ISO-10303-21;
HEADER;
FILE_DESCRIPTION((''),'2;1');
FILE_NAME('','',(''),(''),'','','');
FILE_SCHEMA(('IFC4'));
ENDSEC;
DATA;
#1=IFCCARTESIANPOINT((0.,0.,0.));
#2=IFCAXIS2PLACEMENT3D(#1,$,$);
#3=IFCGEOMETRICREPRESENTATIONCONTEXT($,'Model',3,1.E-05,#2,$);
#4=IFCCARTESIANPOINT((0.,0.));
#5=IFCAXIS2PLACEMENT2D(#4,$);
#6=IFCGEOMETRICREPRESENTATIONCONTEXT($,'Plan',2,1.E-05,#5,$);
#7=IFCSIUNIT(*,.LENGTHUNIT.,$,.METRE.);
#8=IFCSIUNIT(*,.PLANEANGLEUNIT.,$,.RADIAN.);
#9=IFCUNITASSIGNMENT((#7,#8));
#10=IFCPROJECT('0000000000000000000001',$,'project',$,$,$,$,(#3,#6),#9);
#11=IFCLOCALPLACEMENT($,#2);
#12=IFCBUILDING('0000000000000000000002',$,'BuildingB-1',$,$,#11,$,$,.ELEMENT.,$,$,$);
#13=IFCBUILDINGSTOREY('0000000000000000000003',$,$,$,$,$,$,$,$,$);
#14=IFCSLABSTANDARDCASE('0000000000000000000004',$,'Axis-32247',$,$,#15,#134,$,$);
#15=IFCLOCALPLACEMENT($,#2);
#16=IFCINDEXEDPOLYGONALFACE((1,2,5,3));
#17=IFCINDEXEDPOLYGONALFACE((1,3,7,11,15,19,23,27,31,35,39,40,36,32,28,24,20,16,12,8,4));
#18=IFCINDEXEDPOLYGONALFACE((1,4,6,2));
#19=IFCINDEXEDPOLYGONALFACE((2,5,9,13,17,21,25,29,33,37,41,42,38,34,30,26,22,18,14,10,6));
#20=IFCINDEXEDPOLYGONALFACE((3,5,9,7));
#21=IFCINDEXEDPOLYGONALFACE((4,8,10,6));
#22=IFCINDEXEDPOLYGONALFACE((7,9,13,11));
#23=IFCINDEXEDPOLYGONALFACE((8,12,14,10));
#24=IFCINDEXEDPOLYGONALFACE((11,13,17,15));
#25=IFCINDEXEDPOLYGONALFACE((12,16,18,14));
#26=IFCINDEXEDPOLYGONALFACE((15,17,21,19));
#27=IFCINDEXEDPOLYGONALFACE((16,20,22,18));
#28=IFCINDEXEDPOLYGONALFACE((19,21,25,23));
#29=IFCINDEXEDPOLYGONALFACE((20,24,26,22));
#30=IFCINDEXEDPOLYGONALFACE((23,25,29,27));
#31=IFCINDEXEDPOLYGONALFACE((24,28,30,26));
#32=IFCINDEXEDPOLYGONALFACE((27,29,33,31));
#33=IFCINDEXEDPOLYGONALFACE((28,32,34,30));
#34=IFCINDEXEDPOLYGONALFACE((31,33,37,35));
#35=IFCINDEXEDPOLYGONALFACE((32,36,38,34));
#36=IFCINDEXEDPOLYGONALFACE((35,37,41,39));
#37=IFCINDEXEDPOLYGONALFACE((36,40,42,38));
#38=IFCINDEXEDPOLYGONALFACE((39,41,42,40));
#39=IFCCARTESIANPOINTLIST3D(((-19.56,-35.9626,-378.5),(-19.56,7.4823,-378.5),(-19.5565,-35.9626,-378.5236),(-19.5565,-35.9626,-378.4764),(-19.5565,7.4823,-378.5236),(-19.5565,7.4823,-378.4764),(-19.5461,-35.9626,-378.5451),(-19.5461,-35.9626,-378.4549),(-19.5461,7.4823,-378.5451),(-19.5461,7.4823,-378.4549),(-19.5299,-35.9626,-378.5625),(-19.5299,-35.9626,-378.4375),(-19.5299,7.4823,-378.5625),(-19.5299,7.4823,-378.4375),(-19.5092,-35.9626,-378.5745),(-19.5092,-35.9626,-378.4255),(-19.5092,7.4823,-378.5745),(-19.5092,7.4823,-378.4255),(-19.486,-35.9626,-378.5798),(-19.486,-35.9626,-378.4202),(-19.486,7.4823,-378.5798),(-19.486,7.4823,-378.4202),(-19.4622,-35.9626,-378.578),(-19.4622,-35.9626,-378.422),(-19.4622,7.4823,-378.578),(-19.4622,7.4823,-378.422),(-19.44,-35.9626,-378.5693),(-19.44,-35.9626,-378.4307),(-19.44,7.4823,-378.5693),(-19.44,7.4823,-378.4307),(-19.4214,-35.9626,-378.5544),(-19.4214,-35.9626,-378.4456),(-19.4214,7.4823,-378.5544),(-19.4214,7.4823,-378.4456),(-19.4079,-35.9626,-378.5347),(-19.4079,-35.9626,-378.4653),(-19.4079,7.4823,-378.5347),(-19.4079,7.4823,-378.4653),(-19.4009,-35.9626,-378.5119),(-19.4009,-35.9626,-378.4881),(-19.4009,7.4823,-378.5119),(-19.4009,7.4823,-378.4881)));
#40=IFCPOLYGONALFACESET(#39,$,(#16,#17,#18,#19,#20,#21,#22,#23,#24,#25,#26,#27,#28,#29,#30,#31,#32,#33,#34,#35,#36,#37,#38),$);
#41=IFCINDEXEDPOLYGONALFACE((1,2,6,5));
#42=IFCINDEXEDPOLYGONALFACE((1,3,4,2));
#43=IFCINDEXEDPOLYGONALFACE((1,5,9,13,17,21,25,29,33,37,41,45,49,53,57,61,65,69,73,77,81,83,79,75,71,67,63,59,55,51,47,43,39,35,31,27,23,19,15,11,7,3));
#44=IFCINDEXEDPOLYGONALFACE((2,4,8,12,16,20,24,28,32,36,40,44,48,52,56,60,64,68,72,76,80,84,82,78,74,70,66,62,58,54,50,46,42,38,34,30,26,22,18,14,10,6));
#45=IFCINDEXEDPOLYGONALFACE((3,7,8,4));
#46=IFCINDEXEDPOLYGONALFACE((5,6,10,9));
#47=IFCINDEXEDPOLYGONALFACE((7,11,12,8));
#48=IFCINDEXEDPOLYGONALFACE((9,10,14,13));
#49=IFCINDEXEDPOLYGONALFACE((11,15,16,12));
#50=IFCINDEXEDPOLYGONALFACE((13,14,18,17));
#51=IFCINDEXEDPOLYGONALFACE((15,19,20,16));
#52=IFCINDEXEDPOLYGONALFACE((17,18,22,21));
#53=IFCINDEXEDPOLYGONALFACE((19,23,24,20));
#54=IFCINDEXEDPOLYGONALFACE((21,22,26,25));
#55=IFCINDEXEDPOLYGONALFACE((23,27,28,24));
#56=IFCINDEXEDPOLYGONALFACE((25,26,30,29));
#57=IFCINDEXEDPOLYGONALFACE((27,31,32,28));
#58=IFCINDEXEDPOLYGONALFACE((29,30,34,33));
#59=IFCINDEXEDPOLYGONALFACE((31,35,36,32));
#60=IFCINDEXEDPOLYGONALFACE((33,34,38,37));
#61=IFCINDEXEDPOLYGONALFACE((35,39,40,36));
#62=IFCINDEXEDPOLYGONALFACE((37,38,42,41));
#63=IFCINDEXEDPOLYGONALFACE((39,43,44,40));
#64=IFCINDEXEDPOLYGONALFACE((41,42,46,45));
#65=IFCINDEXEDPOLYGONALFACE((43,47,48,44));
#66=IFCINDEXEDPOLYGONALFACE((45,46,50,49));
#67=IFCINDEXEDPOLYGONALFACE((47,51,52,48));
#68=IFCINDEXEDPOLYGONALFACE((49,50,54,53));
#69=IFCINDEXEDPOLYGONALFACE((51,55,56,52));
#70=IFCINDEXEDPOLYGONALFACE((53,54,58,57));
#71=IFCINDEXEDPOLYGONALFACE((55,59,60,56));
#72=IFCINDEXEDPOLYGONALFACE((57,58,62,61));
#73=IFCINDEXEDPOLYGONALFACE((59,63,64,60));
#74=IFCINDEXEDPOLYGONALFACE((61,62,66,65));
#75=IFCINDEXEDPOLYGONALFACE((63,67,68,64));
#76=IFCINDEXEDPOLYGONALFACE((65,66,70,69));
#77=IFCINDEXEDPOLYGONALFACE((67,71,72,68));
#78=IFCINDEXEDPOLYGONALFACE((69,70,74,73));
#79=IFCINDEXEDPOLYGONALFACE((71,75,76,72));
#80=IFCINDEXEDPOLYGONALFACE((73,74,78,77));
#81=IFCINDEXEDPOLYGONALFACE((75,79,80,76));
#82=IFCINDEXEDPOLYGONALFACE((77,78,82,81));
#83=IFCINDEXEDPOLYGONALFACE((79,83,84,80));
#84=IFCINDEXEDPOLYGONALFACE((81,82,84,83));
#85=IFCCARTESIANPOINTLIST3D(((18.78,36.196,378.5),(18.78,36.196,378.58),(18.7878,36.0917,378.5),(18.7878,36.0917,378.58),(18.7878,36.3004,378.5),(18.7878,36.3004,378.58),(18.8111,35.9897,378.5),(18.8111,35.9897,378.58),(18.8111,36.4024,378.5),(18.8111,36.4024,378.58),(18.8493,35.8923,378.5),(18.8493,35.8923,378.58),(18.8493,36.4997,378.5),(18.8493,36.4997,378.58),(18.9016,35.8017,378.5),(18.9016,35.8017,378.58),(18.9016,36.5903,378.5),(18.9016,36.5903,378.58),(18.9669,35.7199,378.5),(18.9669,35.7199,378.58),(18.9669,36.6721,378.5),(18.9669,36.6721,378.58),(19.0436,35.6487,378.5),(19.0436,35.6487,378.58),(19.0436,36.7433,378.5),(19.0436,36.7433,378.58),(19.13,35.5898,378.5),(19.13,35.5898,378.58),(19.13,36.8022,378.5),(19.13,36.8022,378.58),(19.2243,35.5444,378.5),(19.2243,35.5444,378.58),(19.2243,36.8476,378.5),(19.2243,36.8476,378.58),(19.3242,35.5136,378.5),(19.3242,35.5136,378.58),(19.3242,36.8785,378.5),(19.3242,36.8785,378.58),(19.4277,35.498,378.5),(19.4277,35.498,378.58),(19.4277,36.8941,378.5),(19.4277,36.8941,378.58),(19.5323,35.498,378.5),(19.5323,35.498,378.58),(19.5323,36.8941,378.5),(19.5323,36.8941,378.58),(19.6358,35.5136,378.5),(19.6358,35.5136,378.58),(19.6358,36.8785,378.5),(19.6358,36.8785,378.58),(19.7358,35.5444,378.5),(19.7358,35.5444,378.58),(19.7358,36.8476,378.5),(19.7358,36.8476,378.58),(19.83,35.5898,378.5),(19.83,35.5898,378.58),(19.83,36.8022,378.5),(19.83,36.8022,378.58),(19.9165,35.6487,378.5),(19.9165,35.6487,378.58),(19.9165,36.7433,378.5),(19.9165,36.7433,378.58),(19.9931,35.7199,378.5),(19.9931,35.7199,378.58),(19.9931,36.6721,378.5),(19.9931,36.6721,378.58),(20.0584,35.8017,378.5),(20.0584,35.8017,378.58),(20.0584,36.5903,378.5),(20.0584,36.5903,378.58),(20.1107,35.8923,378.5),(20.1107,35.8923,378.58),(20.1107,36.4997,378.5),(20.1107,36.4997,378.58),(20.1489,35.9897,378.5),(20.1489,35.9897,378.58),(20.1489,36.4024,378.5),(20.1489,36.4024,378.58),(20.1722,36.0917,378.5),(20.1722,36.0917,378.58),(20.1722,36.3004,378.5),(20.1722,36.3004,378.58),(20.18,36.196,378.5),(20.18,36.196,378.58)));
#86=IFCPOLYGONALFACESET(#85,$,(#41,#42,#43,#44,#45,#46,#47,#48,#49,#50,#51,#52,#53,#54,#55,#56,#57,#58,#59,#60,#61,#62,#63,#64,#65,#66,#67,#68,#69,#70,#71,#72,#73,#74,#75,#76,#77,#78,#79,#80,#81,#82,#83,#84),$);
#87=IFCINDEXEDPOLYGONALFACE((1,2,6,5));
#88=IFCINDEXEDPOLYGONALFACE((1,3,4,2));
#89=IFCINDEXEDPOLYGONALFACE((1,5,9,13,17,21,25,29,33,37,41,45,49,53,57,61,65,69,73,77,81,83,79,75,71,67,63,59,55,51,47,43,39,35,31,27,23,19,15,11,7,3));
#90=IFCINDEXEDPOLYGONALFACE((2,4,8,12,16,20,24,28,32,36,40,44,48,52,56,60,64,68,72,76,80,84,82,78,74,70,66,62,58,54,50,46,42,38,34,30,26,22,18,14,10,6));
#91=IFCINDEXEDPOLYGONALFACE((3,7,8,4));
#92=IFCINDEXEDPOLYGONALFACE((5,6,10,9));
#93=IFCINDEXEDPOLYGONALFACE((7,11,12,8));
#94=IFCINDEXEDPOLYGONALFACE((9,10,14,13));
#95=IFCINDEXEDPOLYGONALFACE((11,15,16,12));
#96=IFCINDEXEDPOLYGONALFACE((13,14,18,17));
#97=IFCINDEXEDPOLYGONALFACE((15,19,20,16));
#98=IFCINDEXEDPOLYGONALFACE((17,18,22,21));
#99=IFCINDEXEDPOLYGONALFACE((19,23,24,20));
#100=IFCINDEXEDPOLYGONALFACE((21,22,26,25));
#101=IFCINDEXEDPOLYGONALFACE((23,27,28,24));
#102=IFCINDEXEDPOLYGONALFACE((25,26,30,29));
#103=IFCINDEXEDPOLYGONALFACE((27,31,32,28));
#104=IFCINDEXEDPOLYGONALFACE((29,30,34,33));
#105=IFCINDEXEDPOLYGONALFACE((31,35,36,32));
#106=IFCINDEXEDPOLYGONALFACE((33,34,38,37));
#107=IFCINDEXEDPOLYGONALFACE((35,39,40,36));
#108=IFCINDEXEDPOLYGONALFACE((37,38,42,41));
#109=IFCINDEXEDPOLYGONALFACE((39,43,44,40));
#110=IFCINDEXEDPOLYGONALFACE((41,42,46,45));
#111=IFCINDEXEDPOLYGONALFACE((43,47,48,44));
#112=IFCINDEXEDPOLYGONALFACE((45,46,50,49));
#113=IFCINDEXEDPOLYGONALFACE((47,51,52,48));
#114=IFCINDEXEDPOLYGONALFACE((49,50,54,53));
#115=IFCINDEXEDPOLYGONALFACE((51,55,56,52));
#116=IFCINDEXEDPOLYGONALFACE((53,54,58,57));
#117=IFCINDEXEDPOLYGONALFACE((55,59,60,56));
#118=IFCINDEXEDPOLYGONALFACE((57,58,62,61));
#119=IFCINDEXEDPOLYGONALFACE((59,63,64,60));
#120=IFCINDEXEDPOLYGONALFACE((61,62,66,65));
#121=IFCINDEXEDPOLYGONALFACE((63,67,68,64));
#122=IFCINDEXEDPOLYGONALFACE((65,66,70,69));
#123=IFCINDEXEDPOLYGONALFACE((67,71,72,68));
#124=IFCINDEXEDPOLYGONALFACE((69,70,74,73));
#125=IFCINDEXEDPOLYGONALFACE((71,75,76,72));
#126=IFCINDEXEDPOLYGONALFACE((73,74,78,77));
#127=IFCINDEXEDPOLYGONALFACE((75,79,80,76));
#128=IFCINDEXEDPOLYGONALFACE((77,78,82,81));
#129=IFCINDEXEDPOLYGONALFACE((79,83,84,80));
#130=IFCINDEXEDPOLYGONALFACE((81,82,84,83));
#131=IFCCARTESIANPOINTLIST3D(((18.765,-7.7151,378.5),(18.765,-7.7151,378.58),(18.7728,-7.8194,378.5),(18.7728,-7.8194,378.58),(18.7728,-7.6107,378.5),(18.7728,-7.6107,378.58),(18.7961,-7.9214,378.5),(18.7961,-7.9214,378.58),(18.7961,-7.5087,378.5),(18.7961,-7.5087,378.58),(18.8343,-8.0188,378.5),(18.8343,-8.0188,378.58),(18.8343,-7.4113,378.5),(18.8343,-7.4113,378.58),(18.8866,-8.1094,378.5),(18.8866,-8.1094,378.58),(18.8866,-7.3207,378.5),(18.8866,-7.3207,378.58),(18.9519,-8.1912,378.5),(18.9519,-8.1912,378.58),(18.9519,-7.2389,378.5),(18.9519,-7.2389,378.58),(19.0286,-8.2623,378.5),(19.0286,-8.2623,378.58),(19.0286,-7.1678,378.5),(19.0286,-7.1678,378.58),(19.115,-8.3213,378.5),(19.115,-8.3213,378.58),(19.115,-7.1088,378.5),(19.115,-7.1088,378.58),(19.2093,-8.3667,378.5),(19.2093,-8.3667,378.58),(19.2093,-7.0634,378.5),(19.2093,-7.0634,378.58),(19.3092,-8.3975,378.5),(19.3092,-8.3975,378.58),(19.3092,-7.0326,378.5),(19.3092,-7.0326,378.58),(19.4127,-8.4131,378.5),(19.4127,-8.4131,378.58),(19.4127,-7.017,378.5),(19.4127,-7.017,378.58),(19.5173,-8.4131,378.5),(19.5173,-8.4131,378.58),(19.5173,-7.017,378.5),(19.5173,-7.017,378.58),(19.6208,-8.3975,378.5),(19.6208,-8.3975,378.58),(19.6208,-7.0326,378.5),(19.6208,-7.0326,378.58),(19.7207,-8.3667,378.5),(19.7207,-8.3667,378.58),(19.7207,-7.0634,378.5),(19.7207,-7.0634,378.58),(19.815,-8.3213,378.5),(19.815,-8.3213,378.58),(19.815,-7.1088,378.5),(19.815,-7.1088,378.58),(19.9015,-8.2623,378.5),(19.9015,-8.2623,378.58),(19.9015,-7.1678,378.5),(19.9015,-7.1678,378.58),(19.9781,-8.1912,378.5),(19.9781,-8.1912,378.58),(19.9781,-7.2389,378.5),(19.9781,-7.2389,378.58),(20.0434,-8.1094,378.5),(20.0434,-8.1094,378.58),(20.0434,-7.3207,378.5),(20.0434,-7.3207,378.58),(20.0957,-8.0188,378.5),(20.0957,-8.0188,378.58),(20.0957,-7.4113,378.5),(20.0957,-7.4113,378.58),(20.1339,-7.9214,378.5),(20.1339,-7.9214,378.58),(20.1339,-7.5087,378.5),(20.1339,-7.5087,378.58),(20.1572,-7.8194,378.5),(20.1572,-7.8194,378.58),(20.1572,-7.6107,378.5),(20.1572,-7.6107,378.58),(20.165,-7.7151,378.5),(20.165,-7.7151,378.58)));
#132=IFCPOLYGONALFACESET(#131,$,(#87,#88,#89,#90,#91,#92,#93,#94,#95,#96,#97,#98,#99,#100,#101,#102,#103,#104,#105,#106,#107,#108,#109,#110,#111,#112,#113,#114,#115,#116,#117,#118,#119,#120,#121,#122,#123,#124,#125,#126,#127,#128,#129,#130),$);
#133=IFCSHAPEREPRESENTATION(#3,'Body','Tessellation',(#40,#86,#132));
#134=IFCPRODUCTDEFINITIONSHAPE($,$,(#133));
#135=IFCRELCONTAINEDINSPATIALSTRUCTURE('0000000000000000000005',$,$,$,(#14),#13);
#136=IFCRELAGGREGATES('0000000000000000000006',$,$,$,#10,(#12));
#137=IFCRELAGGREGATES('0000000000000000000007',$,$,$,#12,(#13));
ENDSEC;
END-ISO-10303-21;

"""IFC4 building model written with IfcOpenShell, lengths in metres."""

from ifc_helpers import new_model, entity, si_unit, frame, origin, origin_2d, place, context, project, spatial, circle, extrude, element, save


model = new_model("IFC4")

# Units and contexts
model_context = context("Model", 3, precision=1e-05, world=origin())
plan_context = context("Plan", 2, precision=1e-05, world=origin_2d())
ifc_project = project(units=[si_unit("LENGTHUNIT", "METRE"), si_unit("PLANEANGLEUNIT", "RADIAN")], contexts=[model_context, plan_context])

# Building, storey
building_placement = place(None, origin())
building = spatial("IfcBuilding", under=ifc_project, at=building_placement, Name="BuildingB-1", CompositionType="ELEMENT")
storey = spatial("IfcBuildingStorey", under=building)

# Slab
element("IfcSlabStandardCase", 1, inside=storey, Name="Axis-32247", context=model_context, shape_type="AdvancedSweptSolid", body=[
    entity("IfcSurfaceCurveSweptAreaSolid", entity("IfcCircleProfileDef", "AREA", None, None, 0.08), None, entity("IfcPolyline", [entity("IfcCartesianPoint", [19.48, 35.9626, 378.5]), entity("IfcCartesianPoint", [19.48, -7.4823, 378.5])]), None, None, entity("IfcPlane", entity("IfcAxis2Placement3D", entity("IfcCartesianPoint", [19.48, 35.9626, 378.5]), entity("IfcDirection", [0.0, 0.0, 1.0]), entity("IfcDirection", [1.0, 0.0, 0.0])))),
    extrude(circle(Radius=0.7), frame((19.48, 36.196, 378.5)), (0.0, 0.0, 1.0), 0.08),
    extrude(circle(Radius=0.7), frame((19.465, -7.7151, 378.5)), (0.0, 0.0, 1.0), 0.08),
])

save(model, "model.ifc")
